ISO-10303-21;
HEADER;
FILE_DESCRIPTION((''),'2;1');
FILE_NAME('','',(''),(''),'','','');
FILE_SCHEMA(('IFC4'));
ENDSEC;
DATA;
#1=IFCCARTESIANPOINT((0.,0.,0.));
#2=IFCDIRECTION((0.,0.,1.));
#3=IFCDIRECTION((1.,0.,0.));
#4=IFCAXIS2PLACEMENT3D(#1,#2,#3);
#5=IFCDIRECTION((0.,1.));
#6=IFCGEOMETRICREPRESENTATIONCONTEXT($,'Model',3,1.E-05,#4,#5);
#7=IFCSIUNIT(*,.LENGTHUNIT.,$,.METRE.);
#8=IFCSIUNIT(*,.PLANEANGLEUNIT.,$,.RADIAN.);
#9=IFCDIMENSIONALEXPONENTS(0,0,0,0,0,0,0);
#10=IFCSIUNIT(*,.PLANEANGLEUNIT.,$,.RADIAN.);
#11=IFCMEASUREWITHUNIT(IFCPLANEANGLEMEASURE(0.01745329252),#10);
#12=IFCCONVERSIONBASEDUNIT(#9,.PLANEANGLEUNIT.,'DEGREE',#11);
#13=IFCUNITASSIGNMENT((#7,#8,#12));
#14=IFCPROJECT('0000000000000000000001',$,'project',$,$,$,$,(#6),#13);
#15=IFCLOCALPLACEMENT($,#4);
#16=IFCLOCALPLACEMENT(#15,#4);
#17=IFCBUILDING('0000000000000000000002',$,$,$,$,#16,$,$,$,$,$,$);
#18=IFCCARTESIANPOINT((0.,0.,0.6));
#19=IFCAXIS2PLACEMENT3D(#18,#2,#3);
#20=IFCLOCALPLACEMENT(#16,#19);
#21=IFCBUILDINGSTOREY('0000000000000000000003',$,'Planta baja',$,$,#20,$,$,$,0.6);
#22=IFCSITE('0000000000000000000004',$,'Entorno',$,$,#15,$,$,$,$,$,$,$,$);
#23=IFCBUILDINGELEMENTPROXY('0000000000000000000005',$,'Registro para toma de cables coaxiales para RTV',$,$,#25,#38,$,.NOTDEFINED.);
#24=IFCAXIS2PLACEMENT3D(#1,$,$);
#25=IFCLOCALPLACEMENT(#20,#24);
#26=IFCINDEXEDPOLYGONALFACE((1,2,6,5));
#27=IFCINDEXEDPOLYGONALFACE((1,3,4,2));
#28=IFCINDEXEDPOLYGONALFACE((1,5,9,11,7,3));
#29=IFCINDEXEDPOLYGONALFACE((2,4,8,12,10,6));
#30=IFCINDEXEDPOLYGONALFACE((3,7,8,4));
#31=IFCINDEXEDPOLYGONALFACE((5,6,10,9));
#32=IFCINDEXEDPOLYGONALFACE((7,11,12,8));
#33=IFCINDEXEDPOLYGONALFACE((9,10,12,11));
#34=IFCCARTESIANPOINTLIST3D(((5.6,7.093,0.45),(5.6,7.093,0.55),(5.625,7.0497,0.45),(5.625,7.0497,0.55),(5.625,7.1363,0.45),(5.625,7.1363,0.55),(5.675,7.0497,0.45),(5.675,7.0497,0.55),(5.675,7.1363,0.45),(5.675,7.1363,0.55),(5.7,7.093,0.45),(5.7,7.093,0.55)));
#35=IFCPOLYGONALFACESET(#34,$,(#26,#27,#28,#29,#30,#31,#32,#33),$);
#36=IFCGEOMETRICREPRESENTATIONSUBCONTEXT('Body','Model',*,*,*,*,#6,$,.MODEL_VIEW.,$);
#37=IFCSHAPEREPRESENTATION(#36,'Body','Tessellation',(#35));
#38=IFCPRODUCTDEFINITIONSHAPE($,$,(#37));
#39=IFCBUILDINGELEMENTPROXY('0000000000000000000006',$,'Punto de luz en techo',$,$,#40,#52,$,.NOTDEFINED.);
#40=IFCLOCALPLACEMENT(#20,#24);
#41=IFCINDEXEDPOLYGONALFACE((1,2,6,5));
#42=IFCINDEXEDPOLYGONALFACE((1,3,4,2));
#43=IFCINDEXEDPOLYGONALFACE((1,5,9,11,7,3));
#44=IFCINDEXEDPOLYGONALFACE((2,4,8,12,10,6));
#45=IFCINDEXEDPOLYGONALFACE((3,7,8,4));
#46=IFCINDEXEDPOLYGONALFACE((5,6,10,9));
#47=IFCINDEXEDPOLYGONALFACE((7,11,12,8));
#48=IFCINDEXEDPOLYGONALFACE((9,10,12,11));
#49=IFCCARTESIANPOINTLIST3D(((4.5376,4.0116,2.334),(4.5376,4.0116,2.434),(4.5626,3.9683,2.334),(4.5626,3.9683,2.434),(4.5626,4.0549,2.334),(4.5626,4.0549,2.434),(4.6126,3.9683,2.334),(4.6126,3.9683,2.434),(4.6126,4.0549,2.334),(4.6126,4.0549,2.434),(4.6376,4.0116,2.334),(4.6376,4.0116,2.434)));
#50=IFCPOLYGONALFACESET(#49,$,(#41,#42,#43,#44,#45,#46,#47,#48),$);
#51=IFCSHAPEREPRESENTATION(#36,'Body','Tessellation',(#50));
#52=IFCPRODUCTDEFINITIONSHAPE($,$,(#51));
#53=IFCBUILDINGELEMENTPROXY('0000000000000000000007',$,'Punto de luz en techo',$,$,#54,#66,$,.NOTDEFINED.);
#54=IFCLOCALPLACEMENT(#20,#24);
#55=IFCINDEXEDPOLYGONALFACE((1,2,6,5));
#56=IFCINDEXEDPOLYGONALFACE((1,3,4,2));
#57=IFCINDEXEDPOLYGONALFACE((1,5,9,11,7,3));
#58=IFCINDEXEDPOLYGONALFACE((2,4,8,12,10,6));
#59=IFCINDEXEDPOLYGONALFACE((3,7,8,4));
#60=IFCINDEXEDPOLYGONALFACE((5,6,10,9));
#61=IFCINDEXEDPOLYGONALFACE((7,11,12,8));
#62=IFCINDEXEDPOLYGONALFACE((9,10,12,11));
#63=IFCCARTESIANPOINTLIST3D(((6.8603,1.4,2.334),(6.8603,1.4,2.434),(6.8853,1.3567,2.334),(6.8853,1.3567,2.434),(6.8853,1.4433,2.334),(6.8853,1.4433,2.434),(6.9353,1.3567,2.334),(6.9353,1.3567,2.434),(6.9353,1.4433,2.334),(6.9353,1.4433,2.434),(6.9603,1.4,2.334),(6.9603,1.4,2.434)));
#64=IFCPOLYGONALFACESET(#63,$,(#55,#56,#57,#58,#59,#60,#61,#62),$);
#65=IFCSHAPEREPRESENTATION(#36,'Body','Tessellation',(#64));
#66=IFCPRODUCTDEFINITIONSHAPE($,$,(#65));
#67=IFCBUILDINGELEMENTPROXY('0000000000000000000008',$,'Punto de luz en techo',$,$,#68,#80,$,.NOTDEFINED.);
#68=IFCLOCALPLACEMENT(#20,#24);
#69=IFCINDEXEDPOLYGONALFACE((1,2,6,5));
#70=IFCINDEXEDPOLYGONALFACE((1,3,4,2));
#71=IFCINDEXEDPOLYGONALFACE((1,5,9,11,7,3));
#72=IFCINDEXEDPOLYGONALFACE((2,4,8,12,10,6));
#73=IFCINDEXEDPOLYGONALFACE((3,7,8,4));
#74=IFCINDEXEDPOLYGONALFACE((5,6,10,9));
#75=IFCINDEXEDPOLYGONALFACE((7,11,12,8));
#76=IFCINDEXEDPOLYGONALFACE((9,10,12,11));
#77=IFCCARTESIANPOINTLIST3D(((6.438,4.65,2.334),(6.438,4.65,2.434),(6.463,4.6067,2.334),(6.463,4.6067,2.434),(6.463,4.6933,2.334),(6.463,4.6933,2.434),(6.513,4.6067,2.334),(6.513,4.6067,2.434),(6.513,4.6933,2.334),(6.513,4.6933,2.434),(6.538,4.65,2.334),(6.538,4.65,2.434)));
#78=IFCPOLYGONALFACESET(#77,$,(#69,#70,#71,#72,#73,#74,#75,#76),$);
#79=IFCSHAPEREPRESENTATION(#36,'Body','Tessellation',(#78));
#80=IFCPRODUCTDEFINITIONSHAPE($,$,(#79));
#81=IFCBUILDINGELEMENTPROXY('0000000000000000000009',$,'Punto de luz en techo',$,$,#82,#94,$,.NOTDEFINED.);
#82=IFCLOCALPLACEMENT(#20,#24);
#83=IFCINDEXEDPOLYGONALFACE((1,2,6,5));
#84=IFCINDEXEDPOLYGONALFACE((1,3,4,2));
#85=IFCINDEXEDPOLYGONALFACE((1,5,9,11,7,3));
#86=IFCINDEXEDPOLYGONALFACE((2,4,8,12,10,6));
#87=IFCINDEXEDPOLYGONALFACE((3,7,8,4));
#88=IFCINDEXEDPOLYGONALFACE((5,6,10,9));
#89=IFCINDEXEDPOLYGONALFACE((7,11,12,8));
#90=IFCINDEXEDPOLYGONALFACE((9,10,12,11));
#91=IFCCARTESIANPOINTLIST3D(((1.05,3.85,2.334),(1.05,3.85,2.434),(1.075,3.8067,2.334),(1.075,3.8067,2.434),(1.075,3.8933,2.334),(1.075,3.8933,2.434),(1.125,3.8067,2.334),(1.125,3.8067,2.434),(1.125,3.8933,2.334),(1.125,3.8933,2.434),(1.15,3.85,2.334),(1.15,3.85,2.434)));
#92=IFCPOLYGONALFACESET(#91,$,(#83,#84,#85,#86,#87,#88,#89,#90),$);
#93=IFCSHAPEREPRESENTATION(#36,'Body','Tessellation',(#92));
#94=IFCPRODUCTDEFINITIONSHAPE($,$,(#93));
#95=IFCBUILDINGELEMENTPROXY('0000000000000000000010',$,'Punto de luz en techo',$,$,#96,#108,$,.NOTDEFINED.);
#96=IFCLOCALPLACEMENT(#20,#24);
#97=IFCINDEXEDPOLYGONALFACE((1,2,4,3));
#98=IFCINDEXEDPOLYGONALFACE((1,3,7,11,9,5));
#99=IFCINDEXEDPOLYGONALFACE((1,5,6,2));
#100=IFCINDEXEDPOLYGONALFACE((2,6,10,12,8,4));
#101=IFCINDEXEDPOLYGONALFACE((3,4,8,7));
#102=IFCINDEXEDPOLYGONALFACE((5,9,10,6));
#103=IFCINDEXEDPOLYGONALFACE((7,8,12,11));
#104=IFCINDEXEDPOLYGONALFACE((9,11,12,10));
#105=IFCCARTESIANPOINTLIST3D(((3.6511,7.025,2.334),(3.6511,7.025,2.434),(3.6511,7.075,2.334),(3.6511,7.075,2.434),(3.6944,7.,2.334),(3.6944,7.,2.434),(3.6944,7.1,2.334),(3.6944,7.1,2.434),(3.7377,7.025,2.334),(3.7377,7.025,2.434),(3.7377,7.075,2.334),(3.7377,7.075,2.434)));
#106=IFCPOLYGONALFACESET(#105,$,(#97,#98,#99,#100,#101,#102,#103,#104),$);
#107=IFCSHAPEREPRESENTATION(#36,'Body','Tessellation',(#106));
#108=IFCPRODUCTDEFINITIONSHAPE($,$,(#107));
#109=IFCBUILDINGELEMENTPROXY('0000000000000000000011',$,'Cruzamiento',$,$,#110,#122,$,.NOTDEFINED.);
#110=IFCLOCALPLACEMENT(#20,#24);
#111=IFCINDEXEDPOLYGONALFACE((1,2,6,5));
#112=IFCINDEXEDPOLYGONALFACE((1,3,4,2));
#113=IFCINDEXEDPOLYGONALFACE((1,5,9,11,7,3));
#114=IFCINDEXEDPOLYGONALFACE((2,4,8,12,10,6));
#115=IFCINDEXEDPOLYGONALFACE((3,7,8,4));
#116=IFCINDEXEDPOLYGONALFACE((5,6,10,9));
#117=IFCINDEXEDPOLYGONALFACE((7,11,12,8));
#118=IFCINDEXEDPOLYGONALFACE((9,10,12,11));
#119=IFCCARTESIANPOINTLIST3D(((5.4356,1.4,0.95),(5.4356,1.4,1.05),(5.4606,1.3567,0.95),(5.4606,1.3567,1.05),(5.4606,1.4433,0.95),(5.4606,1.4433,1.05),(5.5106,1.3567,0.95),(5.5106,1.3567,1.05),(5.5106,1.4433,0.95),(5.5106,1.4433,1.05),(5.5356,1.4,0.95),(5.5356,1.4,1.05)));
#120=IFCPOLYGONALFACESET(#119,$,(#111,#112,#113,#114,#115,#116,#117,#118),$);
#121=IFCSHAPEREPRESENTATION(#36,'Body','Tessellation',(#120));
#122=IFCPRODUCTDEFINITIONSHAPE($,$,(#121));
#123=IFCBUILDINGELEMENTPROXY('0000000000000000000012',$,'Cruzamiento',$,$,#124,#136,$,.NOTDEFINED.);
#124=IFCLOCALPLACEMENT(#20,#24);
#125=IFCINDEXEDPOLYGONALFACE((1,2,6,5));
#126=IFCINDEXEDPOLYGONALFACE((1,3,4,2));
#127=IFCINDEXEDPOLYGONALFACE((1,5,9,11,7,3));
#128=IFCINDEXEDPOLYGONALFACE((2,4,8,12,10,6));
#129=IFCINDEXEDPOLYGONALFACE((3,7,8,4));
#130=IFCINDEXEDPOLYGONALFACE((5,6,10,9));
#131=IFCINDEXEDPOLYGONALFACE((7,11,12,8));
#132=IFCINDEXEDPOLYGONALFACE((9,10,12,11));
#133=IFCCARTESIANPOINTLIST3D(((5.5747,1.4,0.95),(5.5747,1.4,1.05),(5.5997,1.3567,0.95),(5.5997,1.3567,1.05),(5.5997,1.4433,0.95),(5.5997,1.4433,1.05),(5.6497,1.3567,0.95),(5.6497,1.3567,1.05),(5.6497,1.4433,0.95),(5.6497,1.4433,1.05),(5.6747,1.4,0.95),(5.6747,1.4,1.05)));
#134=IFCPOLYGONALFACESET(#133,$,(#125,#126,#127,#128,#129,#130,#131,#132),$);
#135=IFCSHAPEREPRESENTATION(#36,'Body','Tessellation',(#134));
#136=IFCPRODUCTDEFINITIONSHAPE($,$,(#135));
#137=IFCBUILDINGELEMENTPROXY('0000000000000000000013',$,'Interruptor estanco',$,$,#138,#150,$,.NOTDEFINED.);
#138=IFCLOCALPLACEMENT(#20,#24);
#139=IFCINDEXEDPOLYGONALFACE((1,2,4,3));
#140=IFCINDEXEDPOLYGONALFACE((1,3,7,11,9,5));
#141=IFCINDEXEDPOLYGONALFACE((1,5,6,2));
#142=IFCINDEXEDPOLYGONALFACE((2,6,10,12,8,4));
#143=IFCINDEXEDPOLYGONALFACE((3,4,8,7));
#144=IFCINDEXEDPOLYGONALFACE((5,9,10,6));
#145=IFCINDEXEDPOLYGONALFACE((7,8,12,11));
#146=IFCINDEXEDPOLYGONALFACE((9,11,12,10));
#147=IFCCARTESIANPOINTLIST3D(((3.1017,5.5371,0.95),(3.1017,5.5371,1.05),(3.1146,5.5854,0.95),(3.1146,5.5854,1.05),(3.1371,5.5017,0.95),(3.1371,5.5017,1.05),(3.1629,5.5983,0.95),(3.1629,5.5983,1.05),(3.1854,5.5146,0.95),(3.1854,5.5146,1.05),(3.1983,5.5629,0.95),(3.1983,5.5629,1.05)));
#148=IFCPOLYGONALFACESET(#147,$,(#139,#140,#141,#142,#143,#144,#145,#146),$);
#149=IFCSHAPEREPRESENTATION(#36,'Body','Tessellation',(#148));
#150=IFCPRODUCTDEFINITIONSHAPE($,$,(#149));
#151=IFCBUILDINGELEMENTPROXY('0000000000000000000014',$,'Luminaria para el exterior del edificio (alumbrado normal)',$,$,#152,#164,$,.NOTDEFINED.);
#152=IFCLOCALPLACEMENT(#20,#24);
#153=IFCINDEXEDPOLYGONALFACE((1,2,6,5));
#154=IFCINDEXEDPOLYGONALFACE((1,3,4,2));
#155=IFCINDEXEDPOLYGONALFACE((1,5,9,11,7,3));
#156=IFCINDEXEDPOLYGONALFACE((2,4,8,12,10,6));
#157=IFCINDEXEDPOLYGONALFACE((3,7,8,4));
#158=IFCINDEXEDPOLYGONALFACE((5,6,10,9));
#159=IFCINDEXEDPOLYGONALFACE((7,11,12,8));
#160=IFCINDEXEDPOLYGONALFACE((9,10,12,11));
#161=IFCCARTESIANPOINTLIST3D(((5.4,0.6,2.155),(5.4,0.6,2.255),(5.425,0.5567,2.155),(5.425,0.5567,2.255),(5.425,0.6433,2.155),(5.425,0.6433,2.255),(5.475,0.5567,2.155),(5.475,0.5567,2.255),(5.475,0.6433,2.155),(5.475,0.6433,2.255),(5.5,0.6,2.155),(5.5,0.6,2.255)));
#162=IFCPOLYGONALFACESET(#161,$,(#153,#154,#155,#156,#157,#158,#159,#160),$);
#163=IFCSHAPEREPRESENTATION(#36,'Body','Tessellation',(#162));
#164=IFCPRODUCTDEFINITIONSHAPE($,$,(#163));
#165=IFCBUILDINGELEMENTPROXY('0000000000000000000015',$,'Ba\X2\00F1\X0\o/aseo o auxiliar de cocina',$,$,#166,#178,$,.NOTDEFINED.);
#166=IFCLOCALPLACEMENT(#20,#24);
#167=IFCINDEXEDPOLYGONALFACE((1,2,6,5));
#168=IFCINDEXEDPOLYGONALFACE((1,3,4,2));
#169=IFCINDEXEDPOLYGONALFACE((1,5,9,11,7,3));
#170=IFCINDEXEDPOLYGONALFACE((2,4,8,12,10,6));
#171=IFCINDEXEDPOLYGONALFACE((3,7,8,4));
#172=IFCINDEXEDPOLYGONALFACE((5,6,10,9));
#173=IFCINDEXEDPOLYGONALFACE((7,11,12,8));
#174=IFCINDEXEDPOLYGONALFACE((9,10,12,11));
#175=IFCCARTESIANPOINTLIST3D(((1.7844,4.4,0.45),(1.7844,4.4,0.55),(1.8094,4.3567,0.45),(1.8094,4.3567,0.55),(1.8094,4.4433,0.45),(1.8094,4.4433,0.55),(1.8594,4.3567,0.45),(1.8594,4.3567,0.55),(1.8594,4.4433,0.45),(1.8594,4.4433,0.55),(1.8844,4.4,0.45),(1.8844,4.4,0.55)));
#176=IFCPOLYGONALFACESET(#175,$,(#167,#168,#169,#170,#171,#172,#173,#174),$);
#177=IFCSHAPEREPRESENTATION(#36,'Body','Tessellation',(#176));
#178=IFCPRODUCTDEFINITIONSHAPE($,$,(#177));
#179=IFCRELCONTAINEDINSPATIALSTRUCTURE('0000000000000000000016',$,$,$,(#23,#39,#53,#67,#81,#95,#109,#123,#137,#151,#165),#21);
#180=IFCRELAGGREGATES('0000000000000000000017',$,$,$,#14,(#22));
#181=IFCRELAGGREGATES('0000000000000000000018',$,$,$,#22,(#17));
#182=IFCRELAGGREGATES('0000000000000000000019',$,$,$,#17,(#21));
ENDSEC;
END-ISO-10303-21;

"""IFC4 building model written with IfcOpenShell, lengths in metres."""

from ifc_helpers import new_model, entity, si_unit, converted_unit, direction, frame, origin_with_axes, place, context, subcontext, project, spatial, polyline, outline, extrude, source, transform, mapped, element, save


model = new_model("IFC4")

# Units and contexts
model_context = context("Model", 3, precision=1e-05, world=origin_with_axes(), true_north=direction((0.0, 1.0)))
body_context = subcontext(model_context, "Body", "Model", "MODEL_VIEW")
ifc_project = project(units=[si_unit("LENGTHUNIT", "METRE"), si_unit("PLANEANGLEUNIT", "RADIAN"), converted_unit("PLANEANGLEUNIT", "DEGREE", entity("IfcPlaneAngleMeasure", 0.01745329252), si_unit("PLANEANGLEUNIT", "RADIAN"), dimensions=[0, 0, 0, 0, 0, 0, 0])], contexts=[model_context])

# Site, building, storey
site_placement = place(None, origin_with_axes())
site = spatial("IfcSite", under=ifc_project, at=site_placement, Name="Entorno")
building_placement = place(site_placement, origin_with_axes())
building = spatial("IfcBuilding", under=site, at=building_placement)
storey_placement = place(building_placement, frame((0.0, 0.0, 0.6), z_axis=(0.0, 0.0, 1.0), x_axis=(1.0, 0.0, 0.0)))
storey = spatial("IfcBuildingStorey", under=building, at=storey_placement, Name="Planta baja", Elevation=0.6)

# Building element proxies
shared_shape_1 = source(origin_with_axes(), body_context, "Body", "SolidModel", [
    extrude(outline(polyline([(0.05, 0.0), (0.025, 0.0433), (-0.025, 0.0433), (-0.05, 0.0), (-0.025, -0.0433), (0.025, -0.0433), (0.05, 0.0)])), frame((0.0, 0.0, -0.05), z_axis=(0.0, 0.0, 1.0), x_axis=(1.0, 0.0, 0.0)), (0.0, 0.0, 1.0), 0.1),
])
proxy_1_placement = place(storey_placement, frame((0.0, 0.0, -0.6), z_axis=(0.0, 0.0, 1.0), x_axis=(1.0, 0.0, 0.0)))
element("IfcBuildingElementProxy", 1, at=proxy_1_placement, inside=storey, Name="Registro para toma de cables coaxiales para RTV", PredefinedType="NOTDEFINED", context=body_context, shape_type="Brep", body=[
    mapped(shared_shape_1, transform((5.65, 7.093, 1.1), x_axis=(1.0, 0.0, 0.0), y_axis=(0.0, 1.0, 0.0), z_axis=(0.0, 0.0, 1.0))),
])
shared_shape_2 = source(origin_with_axes(), body_context, "Body", "SolidModel", [
    extrude(outline(polyline([(0.05, 0.0), (0.025, 0.0433), (-0.025, 0.0433), (-0.05, 0.0), (-0.025, -0.0433), (0.025, -0.0433), (0.05, 0.0)])), frame((0.0, 0.0, -0.05), z_axis=(0.0, 0.0, 1.0), x_axis=(1.0, 0.0, 0.0)), (0.0, 0.0, 1.0), 0.1),
])
proxy_2_placement = place(storey_placement, frame((0.0, 0.0, -0.6), z_axis=(0.0, 0.0, 1.0), x_axis=(1.0, 0.0, 0.0)))
element("IfcBuildingElementProxy", 2, at=proxy_2_placement, inside=storey, Name="Punto de luz en techo", PredefinedType="NOTDEFINED", context=body_context, shape_type="Brep", body=[
    mapped(shared_shape_2, transform((4.5876, 4.0116, 2.984), x_axis=(1.0, 0.0, 0.0), y_axis=(0.0, 1.0, 0.0), z_axis=(0.0, 0.0, 1.0))),
])
proxy_3_placement = place(storey_placement, frame((0.0, 0.0, -0.6), z_axis=(0.0, 0.0, 1.0), x_axis=(1.0, 0.0, 0.0)))
element("IfcBuildingElementProxy", 3, at=proxy_3_placement, inside=storey, Name="Punto de luz en techo", PredefinedType="NOTDEFINED", context=body_context, shape_type="Brep", body=[
    mapped(shared_shape_2, transform((6.9103, 1.4, 2.984), x_axis=(1.0, 0.0, 0.0), y_axis=(0.0, 1.0, 0.0), z_axis=(0.0, 0.0, 1.0))),
])
proxy_4_placement = place(storey_placement, frame((0.0, 0.0, -0.6), z_axis=(0.0, 0.0, 1.0), x_axis=(1.0, 0.0, 0.0)))
element("IfcBuildingElementProxy", 4, at=proxy_4_placement, inside=storey, Name="Punto de luz en techo", PredefinedType="NOTDEFINED", context=body_context, shape_type="Brep", body=[
    mapped(shared_shape_2, transform((6.488, 4.65, 2.984), x_axis=(1.0, 0.0, 0.0), y_axis=(0.0, 1.0, 0.0), z_axis=(0.0, 0.0, 1.0))),
])
proxy_5_placement = place(storey_placement, frame((0.0, 0.0, -0.6), z_axis=(0.0, 0.0, 1.0), x_axis=(1.0, 0.0, 0.0)))
element("IfcBuildingElementProxy", 5, at=proxy_5_placement, inside=storey, Name="Punto de luz en techo", PredefinedType="NOTDEFINED", context=body_context, shape_type="Brep", body=[
    mapped(shared_shape_2, transform((1.1, 3.85, 2.984), x_axis=(1.0, 0.0, 0.0), y_axis=(0.0, 1.0, 0.0), z_axis=(0.0, 0.0, 1.0))),
])
proxy_6_placement = place(storey_placement, frame((0.0, 0.0, -0.6), z_axis=(0.0, 0.0, 1.0), x_axis=(1.0, 0.0, 0.0)))
element("IfcBuildingElementProxy", 6, at=proxy_6_placement, inside=storey, Name="Punto de luz en techo", PredefinedType="NOTDEFINED", context=body_context, shape_type="Brep", body=[
    mapped(shared_shape_2, transform((3.6944, 7.05, 2.984), x_axis=(0.0, 1.0, 0.0), y_axis=(-1.0, 0.0, 0.0), z_axis=(0.0, 0.0, 1.0))),
])
shared_shape_3 = source(origin_with_axes(), body_context, "Body", "SolidModel", [
    extrude(outline(polyline([(0.05, 0.0), (0.025, 0.0433), (-0.025, 0.0433), (-0.05, 0.0), (-0.025, -0.0433), (0.025, -0.0433), (0.05, 0.0)])), frame((0.0, 0.0, -0.05), z_axis=(0.0, 0.0, 1.0), x_axis=(1.0, 0.0, 0.0)), (0.0, 0.0, 1.0), 0.1),
])
proxy_7_placement = place(storey_placement, frame((0.0, 0.0, -0.6), z_axis=(0.0, 0.0, 1.0), x_axis=(1.0, 0.0, 0.0)))
element("IfcBuildingElementProxy", 7, at=proxy_7_placement, inside=storey, Name="Cruzamiento", PredefinedType="NOTDEFINED", context=body_context, shape_type="Brep", body=[
    mapped(shared_shape_3, transform((5.4856, 1.4, 1.6), x_axis=(1.0, 0.0, 0.0), y_axis=(0.0, 1.0, 0.0), z_axis=(0.0, 0.0, 1.0))),
])
proxy_8_placement = place(storey_placement, frame((0.0, 0.0, -0.6), z_axis=(0.0, 0.0, 1.0), x_axis=(1.0, 0.0, 0.0)))
element("IfcBuildingElementProxy", 8, at=proxy_8_placement, inside=storey, Name="Cruzamiento", PredefinedType="NOTDEFINED", context=body_context, shape_type="Brep", body=[
    mapped(shared_shape_3, transform((5.6247, 1.4, 1.6), x_axis=(1.0, 0.0, 0.0), y_axis=(0.0, 1.0, 0.0), z_axis=(0.0, 0.0, 1.0))),
])
shared_shape_4 = source(origin_with_axes(), body_context, "Body", "SolidModel", [
    extrude(outline(polyline([(0.05, 0.0), (0.025, 0.0433), (-0.025, 0.0433), (-0.05, 0.0), (-0.025, -0.0433), (0.025, -0.0433), (0.05, 0.0)])), frame((0.0, 0.0, -0.05), z_axis=(0.0, 0.0, 1.0), x_axis=(1.0, 0.0, 0.0)), (0.0, 0.0, 1.0), 0.1),
])
proxy_9_placement = place(storey_placement, frame((0.0, 0.0, -0.6), z_axis=(0.0, 0.0, 1.0), x_axis=(1.0, 0.0, 0.0)))
element("IfcBuildingElementProxy", 9, at=proxy_9_placement, inside=storey, Name="Interruptor estanco", PredefinedType="NOTDEFINED", context=body_context, shape_type="Brep", body=[
    mapped(shared_shape_4, transform((3.15, 5.55, 1.6), x_axis=(0.707107, -0.707107, 0.0), y_axis=(0.707107, 0.707107, 0.0), z_axis=(0.0, 0.0, 1.0))),
])
shared_shape_5 = source(origin_with_axes(), body_context, "Body", "SolidModel", [
    extrude(outline(polyline([(0.05, 0.0), (0.025, 0.0433), (-0.025, 0.0433), (-0.05, 0.0), (-0.025, -0.0433), (0.025, -0.0433), (0.05, 0.0)])), frame((0.0, 0.0, -0.05), z_axis=(0.0, 0.0, 1.0), x_axis=(1.0, 0.0, 0.0)), (0.0, 0.0, 1.0), 0.1),
])
proxy_10_placement = place(storey_placement, frame((0.0, 0.0, -0.6), z_axis=(0.0, 0.0, 1.0), x_axis=(1.0, 0.0, 0.0)))
element("IfcBuildingElementProxy", 10, at=proxy_10_placement, inside=storey, Name="Luminaria para el exterior del edificio (alumbrado normal)", PredefinedType="NOTDEFINED", context=body_context, shape_type="Brep", body=[
    mapped(shared_shape_5, transform((5.45, 0.6, 2.805), x_axis=(-1.0, 0.0, 0.0), y_axis=(0.0, -1.0, 0.0), z_axis=(0.0, 0.0, 1.0))),
])
shared_shape_6 = source(origin_with_axes(), body_context, "Body", "SolidModel", [
    extrude(outline(polyline([(0.05, 0.0), (0.025, 0.0433), (-0.025, 0.0433), (-0.05, 0.0), (-0.025, -0.0433), (0.025, -0.0433), (0.05, 0.0)])), frame((0.0, 0.0, -0.05), z_axis=(0.0, 0.0, 1.0), x_axis=(1.0, 0.0, 0.0)), (0.0, 0.0, 1.0), 0.1),
])
proxy_11_placement = place(storey_placement, frame((0.0, 0.0, -0.6), z_axis=(0.0, 0.0, 1.0), x_axis=(1.0, 0.0, 0.0)))
element("IfcBuildingElementProxy", 11, at=proxy_11_placement, inside=storey, Name="Baño/aseo o auxiliar de cocina", PredefinedType="NOTDEFINED", context=body_context, shape_type="Brep", body=[
    mapped(shared_shape_6, transform((1.8344, 4.4, 1.1), x_axis=(-1.0, 0.0, 0.0), y_axis=(0.0, -1.0, 0.0), z_axis=(0.0, 0.0, 1.0))),
])

save(model, "model.ifc")
